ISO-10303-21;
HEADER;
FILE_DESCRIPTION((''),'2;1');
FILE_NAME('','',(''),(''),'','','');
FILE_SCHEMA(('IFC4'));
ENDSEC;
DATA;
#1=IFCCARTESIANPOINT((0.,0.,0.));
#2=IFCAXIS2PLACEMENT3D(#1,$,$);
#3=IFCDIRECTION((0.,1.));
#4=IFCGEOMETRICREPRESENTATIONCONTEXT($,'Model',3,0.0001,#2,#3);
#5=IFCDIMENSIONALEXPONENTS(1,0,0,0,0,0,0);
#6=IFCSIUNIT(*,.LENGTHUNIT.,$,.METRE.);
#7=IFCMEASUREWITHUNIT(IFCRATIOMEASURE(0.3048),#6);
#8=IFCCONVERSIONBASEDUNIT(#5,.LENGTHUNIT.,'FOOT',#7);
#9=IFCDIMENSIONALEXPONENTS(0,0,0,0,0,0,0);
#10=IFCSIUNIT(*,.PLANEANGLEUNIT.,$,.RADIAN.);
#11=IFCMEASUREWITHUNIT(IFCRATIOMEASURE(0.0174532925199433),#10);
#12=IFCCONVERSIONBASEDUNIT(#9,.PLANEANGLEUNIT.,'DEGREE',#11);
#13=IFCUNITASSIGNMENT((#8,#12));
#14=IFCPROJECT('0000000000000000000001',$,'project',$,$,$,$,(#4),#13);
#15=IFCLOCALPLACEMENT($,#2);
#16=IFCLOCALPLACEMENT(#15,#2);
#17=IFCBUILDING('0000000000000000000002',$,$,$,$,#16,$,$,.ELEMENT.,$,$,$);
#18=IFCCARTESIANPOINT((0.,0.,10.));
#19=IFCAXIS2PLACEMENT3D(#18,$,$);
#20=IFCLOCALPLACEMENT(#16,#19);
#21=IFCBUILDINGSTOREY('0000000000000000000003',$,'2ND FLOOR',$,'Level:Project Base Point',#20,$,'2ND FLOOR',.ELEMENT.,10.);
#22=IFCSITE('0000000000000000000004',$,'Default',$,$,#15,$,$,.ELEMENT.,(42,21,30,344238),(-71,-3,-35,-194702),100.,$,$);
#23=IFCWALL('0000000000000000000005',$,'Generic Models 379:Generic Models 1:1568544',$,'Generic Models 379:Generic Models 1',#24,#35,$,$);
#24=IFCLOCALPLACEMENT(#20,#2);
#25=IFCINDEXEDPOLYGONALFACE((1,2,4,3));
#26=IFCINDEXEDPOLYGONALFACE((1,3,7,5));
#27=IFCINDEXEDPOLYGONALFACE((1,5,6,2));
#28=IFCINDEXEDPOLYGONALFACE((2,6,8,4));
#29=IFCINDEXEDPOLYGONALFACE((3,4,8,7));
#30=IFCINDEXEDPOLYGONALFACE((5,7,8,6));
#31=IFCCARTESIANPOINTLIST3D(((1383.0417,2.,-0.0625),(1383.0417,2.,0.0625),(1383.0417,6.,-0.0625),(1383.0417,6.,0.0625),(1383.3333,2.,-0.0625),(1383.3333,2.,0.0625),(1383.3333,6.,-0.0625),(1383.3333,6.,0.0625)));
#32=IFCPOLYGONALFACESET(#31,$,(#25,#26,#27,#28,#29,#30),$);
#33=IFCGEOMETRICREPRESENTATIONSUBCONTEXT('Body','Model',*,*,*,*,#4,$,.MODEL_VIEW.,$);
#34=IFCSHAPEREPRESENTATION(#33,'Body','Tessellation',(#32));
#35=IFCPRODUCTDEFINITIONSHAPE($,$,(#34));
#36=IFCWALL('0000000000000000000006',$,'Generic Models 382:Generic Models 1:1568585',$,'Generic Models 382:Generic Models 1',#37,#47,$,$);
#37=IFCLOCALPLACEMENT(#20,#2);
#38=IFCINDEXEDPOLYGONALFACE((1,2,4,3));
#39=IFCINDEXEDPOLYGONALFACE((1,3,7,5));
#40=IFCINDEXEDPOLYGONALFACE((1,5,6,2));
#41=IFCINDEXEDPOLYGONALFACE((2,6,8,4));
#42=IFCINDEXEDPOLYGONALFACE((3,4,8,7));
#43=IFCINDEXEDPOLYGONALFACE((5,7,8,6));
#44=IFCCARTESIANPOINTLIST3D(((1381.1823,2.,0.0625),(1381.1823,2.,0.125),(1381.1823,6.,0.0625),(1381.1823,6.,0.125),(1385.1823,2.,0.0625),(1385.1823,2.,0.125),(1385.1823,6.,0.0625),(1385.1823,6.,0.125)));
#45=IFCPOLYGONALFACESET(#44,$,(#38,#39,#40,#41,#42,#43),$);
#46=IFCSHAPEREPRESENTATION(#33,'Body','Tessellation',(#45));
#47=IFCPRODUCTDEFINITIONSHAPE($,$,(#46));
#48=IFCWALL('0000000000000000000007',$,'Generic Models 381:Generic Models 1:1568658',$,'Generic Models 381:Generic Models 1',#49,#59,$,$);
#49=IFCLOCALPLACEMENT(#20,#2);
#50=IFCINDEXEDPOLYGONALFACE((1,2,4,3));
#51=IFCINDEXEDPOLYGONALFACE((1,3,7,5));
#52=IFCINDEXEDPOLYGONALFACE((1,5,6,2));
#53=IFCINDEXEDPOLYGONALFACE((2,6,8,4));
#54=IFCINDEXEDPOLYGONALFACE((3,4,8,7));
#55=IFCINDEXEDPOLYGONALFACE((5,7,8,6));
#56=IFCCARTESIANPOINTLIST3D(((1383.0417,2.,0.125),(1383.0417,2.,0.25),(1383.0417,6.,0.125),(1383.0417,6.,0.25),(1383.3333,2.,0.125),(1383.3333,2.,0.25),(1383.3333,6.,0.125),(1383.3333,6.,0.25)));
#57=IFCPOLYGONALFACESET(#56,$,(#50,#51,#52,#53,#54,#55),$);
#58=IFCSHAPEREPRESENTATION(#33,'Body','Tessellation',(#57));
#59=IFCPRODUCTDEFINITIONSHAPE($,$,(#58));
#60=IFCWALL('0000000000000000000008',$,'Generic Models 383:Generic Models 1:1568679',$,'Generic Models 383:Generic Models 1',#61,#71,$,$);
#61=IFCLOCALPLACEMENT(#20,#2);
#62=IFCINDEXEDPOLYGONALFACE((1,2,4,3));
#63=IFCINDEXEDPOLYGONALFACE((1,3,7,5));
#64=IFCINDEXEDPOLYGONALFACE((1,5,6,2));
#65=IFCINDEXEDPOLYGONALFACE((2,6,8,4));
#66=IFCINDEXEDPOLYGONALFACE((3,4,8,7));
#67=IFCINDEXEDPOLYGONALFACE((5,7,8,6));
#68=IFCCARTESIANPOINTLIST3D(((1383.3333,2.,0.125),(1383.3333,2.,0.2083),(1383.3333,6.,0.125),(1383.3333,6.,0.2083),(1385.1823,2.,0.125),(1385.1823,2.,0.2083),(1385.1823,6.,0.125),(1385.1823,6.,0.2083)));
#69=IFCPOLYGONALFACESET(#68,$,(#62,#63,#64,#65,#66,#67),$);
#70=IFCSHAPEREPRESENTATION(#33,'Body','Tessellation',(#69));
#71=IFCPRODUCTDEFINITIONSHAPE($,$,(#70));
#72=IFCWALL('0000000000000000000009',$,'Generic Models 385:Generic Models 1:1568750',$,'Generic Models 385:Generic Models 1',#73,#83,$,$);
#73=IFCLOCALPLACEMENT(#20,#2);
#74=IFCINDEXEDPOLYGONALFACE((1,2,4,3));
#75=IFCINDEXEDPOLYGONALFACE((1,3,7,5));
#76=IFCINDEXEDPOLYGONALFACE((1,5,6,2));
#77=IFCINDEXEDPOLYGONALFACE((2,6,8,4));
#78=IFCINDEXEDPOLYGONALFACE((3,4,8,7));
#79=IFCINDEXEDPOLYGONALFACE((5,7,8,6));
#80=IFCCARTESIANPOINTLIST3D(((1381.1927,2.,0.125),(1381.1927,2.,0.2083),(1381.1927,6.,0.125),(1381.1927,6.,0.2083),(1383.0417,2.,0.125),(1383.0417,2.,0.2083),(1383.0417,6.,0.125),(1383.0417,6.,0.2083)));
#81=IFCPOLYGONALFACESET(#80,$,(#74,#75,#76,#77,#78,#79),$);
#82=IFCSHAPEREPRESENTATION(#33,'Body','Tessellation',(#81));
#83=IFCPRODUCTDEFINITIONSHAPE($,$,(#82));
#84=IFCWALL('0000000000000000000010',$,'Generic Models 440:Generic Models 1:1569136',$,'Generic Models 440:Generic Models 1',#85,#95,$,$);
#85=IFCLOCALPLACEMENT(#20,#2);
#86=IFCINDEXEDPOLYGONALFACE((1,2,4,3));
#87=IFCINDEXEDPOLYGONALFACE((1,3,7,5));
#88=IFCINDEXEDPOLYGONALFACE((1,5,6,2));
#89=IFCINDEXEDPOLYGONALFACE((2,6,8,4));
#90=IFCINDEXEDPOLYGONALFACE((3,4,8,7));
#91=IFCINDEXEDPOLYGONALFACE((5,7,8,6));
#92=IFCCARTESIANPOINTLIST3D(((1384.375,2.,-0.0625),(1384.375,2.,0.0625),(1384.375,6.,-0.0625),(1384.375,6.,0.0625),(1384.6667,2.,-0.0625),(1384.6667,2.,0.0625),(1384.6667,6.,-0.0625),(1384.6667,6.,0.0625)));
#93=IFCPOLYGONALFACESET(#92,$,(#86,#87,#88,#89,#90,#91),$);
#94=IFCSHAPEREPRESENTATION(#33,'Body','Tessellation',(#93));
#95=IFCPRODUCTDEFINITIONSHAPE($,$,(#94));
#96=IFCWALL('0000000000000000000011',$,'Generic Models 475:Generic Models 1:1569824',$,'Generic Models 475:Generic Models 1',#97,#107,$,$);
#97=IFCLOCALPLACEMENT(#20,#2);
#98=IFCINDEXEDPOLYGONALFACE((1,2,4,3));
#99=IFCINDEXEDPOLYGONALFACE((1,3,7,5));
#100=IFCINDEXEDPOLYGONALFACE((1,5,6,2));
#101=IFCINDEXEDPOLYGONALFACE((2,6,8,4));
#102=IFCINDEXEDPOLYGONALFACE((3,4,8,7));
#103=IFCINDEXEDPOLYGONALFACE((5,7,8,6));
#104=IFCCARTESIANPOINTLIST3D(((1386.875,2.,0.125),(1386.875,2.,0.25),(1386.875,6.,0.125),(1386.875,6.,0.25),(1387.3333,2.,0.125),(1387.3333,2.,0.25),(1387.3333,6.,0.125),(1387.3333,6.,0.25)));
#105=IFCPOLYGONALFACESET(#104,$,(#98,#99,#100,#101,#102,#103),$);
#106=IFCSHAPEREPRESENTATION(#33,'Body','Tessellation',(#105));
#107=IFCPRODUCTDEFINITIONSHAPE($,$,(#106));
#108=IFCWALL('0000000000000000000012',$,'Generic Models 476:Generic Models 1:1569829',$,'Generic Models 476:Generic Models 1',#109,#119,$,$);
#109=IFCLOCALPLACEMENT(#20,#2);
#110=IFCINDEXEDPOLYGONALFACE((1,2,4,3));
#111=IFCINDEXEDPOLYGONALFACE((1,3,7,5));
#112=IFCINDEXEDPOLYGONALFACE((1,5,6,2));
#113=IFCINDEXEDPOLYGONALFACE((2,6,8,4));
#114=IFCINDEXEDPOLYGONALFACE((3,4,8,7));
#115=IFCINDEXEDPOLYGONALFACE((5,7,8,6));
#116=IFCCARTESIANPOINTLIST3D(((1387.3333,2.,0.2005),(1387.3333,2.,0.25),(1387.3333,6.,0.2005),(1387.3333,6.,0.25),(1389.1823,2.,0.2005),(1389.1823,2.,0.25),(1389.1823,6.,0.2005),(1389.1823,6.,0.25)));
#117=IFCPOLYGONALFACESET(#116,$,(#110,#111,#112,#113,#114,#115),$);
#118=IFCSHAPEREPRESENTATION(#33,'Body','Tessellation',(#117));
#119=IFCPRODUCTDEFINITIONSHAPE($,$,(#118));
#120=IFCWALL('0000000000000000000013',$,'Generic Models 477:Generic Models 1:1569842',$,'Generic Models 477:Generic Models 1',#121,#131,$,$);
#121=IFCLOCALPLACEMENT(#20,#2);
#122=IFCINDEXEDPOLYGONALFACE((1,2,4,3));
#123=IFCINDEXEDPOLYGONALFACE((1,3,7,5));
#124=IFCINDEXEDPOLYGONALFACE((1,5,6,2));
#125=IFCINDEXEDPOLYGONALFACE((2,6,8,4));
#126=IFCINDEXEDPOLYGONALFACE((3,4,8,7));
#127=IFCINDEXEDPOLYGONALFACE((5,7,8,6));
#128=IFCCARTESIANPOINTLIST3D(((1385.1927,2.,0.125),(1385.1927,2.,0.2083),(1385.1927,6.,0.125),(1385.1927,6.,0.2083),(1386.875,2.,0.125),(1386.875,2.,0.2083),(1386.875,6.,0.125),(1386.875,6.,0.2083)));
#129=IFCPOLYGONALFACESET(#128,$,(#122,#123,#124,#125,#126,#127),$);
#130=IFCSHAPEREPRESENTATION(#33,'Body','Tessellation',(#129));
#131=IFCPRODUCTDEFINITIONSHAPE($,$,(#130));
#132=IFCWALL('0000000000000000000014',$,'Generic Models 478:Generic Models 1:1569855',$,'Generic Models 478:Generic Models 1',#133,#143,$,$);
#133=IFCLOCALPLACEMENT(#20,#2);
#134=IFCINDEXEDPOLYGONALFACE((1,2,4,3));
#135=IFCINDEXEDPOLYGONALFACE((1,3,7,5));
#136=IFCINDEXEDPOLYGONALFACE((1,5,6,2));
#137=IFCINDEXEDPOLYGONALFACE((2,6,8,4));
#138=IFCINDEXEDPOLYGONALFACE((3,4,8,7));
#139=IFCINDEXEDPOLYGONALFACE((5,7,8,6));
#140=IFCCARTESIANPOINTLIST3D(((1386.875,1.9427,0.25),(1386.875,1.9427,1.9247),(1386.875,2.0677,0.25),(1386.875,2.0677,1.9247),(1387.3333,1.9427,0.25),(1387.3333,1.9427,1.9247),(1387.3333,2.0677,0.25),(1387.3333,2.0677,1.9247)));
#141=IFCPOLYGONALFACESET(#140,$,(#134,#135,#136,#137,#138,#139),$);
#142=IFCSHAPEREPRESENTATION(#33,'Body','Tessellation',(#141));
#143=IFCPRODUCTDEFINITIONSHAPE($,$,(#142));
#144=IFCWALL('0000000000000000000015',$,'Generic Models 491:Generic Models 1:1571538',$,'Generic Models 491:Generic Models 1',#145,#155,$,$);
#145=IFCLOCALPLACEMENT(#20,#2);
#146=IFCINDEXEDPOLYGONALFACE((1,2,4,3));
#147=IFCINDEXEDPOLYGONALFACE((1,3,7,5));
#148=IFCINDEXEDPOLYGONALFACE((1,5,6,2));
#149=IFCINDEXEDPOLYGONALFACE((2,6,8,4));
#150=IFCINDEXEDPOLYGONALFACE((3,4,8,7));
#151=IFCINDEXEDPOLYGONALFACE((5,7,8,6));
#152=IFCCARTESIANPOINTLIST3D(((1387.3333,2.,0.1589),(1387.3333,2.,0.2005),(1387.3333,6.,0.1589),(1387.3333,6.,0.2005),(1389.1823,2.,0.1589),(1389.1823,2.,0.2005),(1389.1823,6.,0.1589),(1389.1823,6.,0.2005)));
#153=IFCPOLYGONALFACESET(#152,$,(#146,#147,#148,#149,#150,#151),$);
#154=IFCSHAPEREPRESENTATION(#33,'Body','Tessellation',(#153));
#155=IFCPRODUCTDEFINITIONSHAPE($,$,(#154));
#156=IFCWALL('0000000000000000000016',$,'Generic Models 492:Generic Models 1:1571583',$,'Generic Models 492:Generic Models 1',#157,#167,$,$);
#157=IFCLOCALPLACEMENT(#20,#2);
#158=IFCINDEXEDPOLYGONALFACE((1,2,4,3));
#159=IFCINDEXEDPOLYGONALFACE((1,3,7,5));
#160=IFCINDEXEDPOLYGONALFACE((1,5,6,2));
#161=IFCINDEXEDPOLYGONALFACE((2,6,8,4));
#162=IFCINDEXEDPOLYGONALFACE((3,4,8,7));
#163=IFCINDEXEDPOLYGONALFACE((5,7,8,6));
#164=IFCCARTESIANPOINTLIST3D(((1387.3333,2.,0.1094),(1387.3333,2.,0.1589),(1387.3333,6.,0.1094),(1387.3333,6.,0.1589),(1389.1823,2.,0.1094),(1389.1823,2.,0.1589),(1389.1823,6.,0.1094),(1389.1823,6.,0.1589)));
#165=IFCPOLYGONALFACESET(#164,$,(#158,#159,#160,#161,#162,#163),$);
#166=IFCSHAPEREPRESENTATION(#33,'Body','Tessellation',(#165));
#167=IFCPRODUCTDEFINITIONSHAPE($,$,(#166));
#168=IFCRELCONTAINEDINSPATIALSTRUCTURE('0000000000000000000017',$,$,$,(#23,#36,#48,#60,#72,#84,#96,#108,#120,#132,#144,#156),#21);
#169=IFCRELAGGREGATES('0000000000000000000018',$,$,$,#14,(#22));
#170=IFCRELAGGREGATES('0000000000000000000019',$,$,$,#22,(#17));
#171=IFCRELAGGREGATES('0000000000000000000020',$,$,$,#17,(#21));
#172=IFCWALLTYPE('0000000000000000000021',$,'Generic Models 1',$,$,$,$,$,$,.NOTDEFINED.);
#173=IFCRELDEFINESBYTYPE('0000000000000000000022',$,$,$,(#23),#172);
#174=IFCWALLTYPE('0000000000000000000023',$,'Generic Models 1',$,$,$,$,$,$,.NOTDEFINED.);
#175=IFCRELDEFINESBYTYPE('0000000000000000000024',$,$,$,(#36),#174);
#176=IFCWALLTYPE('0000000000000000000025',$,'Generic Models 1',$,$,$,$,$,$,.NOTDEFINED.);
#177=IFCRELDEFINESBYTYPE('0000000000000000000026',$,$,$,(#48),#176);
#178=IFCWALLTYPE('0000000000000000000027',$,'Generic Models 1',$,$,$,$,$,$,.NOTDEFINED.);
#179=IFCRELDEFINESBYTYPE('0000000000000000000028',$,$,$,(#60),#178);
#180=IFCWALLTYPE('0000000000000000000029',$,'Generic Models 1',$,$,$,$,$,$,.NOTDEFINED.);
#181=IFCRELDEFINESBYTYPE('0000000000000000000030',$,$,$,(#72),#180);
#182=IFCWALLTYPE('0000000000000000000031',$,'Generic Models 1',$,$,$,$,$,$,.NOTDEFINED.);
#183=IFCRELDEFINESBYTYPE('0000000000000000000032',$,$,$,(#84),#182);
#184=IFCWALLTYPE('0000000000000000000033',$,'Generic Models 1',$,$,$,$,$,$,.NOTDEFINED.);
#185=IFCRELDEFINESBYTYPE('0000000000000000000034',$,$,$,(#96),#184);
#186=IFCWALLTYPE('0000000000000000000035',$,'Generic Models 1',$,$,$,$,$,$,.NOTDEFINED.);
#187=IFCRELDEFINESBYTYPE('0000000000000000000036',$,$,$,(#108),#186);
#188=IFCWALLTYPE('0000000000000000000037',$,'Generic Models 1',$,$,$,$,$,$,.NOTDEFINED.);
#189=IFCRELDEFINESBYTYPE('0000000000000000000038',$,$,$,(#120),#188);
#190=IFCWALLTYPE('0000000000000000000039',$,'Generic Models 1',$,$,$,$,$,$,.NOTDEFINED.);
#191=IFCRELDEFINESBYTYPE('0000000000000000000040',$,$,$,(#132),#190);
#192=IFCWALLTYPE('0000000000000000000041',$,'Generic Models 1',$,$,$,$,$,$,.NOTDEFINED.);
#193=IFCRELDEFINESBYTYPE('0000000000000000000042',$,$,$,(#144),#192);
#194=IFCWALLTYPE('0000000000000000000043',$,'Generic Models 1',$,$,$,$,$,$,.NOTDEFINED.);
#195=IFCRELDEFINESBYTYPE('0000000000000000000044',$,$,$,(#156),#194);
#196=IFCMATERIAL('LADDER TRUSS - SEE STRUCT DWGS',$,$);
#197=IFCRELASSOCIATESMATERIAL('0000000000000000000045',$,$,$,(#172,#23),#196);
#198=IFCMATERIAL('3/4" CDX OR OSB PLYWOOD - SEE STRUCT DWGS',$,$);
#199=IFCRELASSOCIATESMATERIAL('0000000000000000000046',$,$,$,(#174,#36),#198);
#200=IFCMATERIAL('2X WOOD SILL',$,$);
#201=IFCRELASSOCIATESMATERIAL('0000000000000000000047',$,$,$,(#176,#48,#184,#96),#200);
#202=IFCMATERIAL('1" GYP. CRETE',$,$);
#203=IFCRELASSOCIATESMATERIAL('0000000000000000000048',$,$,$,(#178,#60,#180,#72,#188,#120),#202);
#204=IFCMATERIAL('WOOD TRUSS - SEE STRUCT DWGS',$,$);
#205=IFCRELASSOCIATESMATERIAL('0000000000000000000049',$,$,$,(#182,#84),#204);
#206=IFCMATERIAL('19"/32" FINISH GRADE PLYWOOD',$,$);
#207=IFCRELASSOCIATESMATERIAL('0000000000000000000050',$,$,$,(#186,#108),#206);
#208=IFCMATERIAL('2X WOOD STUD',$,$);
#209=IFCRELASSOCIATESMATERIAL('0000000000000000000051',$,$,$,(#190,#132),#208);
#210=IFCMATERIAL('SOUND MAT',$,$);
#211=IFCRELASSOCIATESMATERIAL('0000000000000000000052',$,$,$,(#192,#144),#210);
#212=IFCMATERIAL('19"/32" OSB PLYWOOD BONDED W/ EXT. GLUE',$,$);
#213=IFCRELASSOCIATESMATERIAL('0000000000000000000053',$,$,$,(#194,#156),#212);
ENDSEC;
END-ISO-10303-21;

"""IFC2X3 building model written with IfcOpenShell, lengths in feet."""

from ifc_helpers import new_model, entity, si_unit, converted_unit, direction, frame, frame_2d, origin, origin_2d_with_axis, place, context, subcontext, project, spatial, rectangle, extrude, material, type_object, element, save


model = new_model("IFC2X3")

# Units and contexts
model_context = context("Model", 3, precision=0.0001, world=origin(), true_north=direction((0.0, 1.0)))
body_context = subcontext(model_context, "Body", "Model", "MODEL_VIEW")
ifc_project = project(units=[converted_unit("LENGTHUNIT", "FOOT", entity("IfcRatioMeasure", 0.3048), si_unit("LENGTHUNIT", "METRE"), dimensions=[1, 0, 0, 0, 0, 0, 0]), converted_unit("PLANEANGLEUNIT", "DEGREE", entity("IfcRatioMeasure", 0.0174532925199433), si_unit("PLANEANGLEUNIT", "RADIAN"), dimensions=[0, 0, 0, 0, 0, 0, 0])], contexts=[model_context])

# Site, building, storey
site_placement = place(None, origin())
site = spatial("IfcSite", under=ifc_project, at=site_placement, Name="Default", CompositionType="ELEMENT", RefLatitude=(42, 21, 30, 344238), RefLongitude=(-71, -3, -35, -194702), RefElevation=100.0)
building_placement = place(site_placement, origin())
building = spatial("IfcBuilding", under=site, at=building_placement, CompositionType="ELEMENT")
storey_placement = place(building_placement, frame((0.0, 0.0, 10.0)))
storey = spatial("IfcBuildingStorey", under=building, at=storey_placement, Name="2ND FLOOR", ObjectType="Level:Project Base Point", LongName="2ND FLOOR", CompositionType="ELEMENT", Elevation=10.0)

# Walls
ifc_material_1 = material(Name="LADDER TRUSS - SEE STRUCT DWGS")
wall_type_1 = type_object("IfcWallType", Name="Generic Models 1", PredefinedType="NOTDEFINED", material=ifc_material_1)
wall_1_placement = place(storey_placement, frame((1383.0417, 2.0, -0.0625), z_axis=(0.0, 0.0, 1.0), x_axis=(0.0, 1.0, 0.0)))
element("IfcWall", 1, at=wall_1_placement, inside=storey, type_object=wall_type_1, material=ifc_material_1, Name="Generic Models 379:Generic Models 1:1568544", ObjectType="Generic Models 379:Generic Models 1", context=body_context, shape_type="SweptSolid", body=[
    extrude(rectangle(XDim=4.0, YDim=0.2917, at=origin_2d_with_axis()), frame((2.0, -0.1458, 0.0)), (0.0, 0.0, 1.0), 0.125),
])
ifc_material_2 = material(Name="3/4\" CDX OR OSB PLYWOOD - SEE STRUCT DWGS")
wall_type_2 = type_object("IfcWallType", Name="Generic Models 1", PredefinedType="NOTDEFINED", material=ifc_material_2)
wall_2_placement = place(storey_placement, frame((1381.1823, 2.0, 0.0625), z_axis=(0.0, 0.0, 1.0), x_axis=(0.0, 1.0, 0.0)))
element("IfcWall", 2, at=wall_2_placement, inside=storey, type_object=wall_type_2, material=ifc_material_2, Name="Generic Models 382:Generic Models 1:1568585", ObjectType="Generic Models 382:Generic Models 1", context=body_context, shape_type="SweptSolid", body=[
    extrude(rectangle(XDim=4.0, YDim=4.0, at=frame_2d((0.0, 0.0), x_axis=(1.0, 0.0))), frame((2.0, -2.0, 0.0)), (0.0, 0.0, 1.0), 0.0625),
])
ifc_material_3 = material(Name="2X WOOD SILL")
wall_type_3 = type_object("IfcWallType", Name="Generic Models 1", PredefinedType="NOTDEFINED", material=ifc_material_3)
wall_3_placement = place(storey_placement, frame((1383.0417, 2.0, 0.125), z_axis=(0.0, 0.0, 1.0), x_axis=(0.0, 1.0, 0.0)))
element("IfcWall", 3, at=wall_3_placement, inside=storey, type_object=wall_type_3, material=ifc_material_3, Name="Generic Models 381:Generic Models 1:1568658", ObjectType="Generic Models 381:Generic Models 1", context=body_context, shape_type="SweptSolid", body=[
    extrude(rectangle(XDim=4.0, YDim=0.2917, at=frame_2d((0.0, 0.0), x_axis=(1.0, 0.0))), frame((2.0, -0.1458, 0.0)), (0.0, 0.0, 1.0), 0.125),
])
ifc_material_4 = material(Name="1\" GYP. CRETE")
wall_type_4 = type_object("IfcWallType", Name="Generic Models 1", PredefinedType="NOTDEFINED", material=ifc_material_4)
wall_4_placement = place(storey_placement, frame((1383.3333, 2.0, 0.125), z_axis=(0.0, 0.0, 1.0), x_axis=(0.0, 1.0, 0.0)))
element("IfcWall", 4, at=wall_4_placement, inside=storey, type_object=wall_type_4, material=ifc_material_4, Name="Generic Models 383:Generic Models 1:1568679", ObjectType="Generic Models 383:Generic Models 1", context=body_context, shape_type="SweptSolid", body=[
    extrude(rectangle(XDim=4.0, YDim=1.849, at=frame_2d((0.0, 0.0), x_axis=(1.0, 0.0))), frame((2.0, -0.9245, 0.0)), (0.0, 0.0, 1.0), 0.0833),
])
wall_type_5 = type_object("IfcWallType", Name="Generic Models 1", PredefinedType="NOTDEFINED", material=ifc_material_4)
wall_5_placement = place(storey_placement, frame((1381.1927, 2.0, 0.125), z_axis=(0.0, 0.0, 1.0), x_axis=(0.0, 1.0, 0.0)))
element("IfcWall", 5, at=wall_5_placement, inside=storey, type_object=wall_type_5, material=ifc_material_4, Name="Generic Models 385:Generic Models 1:1568750", ObjectType="Generic Models 385:Generic Models 1", context=body_context, shape_type="SweptSolid", body=[
    extrude(rectangle(XDim=4.0, YDim=1.849, at=frame_2d((0.0, 0.0), x_axis=(1.0, 0.0))), frame((2.0, -0.9245, 0.0)), (0.0, 0.0, 1.0), 0.0833),
])
ifc_material_5 = material(Name="WOOD TRUSS - SEE STRUCT DWGS")
wall_type_6 = type_object("IfcWallType", Name="Generic Models 1", PredefinedType="NOTDEFINED", material=ifc_material_5)
wall_6_placement = place(storey_placement, frame((1384.375, 2.0, -0.0625), z_axis=(0.0, 0.0, 1.0), x_axis=(0.0, 1.0, 0.0)))
element("IfcWall", 6, at=wall_6_placement, inside=storey, type_object=wall_type_6, material=ifc_material_5, Name="Generic Models 440:Generic Models 1:1569136", ObjectType="Generic Models 440:Generic Models 1", context=body_context, shape_type="SweptSolid", body=[
    extrude(rectangle(XDim=4.0, YDim=0.2917, at=frame_2d((0.0, 0.0), x_axis=(1.0, 0.0))), frame((2.0, -0.1458, 0.0)), (0.0, 0.0, 1.0), 0.125),
])
wall_type_7 = type_object("IfcWallType", Name="Generic Models 1", PredefinedType="NOTDEFINED", material=ifc_material_3)
wall_7_placement = place(storey_placement, frame((1386.875, 2.0, 0.125), z_axis=(0.0, 0.0, 1.0), x_axis=(0.0, 1.0, 0.0)))
element("IfcWall", 7, at=wall_7_placement, inside=storey, type_object=wall_type_7, material=ifc_material_3, Name="Generic Models 475:Generic Models 1:1569824", ObjectType="Generic Models 475:Generic Models 1", context=body_context, shape_type="SweptSolid", body=[
    extrude(rectangle(XDim=4.0, YDim=0.4583, at=frame_2d((0.0, 0.0), x_axis=(1.0, 0.0))), frame((2.0, -0.2292, 0.0)), (0.0, 0.0, 1.0), 0.125),
])
ifc_material_6 = material(Name="19\"/32\" FINISH GRADE PLYWOOD")
wall_type_8 = type_object("IfcWallType", Name="Generic Models 1", PredefinedType="NOTDEFINED", material=ifc_material_6)
wall_8_placement = place(storey_placement, frame((1387.3333, 2.0, 0.2005), z_axis=(0.0, 0.0, 1.0), x_axis=(0.0, 1.0, 0.0)))
element("IfcWall", 8, at=wall_8_placement, inside=storey, type_object=wall_type_8, material=ifc_material_6, Name="Generic Models 476:Generic Models 1:1569829", ObjectType="Generic Models 476:Generic Models 1", context=body_context, shape_type="SweptSolid", body=[
    extrude(rectangle(XDim=4.0, YDim=1.849, at=frame_2d((0.0, 0.0), x_axis=(1.0, 0.0))), frame((2.0, -0.9245, 0.0)), (0.0, 0.0, 1.0), 0.0495),
])
wall_type_9 = type_object("IfcWallType", Name="Generic Models 1", PredefinedType="NOTDEFINED", material=ifc_material_4)
wall_9_placement = place(storey_placement, frame((1385.1927, 2.0, 0.125), z_axis=(0.0, 0.0, 1.0), x_axis=(0.0, 1.0, 0.0)))
element("IfcWall", 9, at=wall_9_placement, inside=storey, type_object=wall_type_9, material=ifc_material_4, Name="Generic Models 477:Generic Models 1:1569842", ObjectType="Generic Models 477:Generic Models 1", context=body_context, shape_type="SweptSolid", body=[
    extrude(rectangle(XDim=4.0, YDim=1.6823, at=frame_2d((0.0, 0.0), x_axis=(1.0, 0.0))), frame((2.0, -0.8411, 0.0)), (0.0, 0.0, 1.0), 0.0833),
])
ifc_material_7 = material(Name="2X WOOD STUD")
wall_type_10 = type_object("IfcWallType", Name="Generic Models 1", PredefinedType="NOTDEFINED", material=ifc_material_7)
wall_10_placement = place(storey_placement, frame((1386.875, 1.9427, 0.25)))
element("IfcWall", 10, at=wall_10_placement, inside=storey, type_object=wall_type_10, material=ifc_material_7, Name="Generic Models 478:Generic Models 1:1569855", ObjectType="Generic Models 478:Generic Models 1", context=body_context, shape_type="SweptSolid", body=[
    extrude(rectangle(XDim=0.125, YDim=0.4583, at=frame_2d((0.0, 0.0), x_axis=(1.0, 0.0))), frame((0.2292, 0.0625, 0.0), z_axis=(0.0, 0.0, 1.0), x_axis=(0.0, 1.0, 0.0)), (0.0, 0.0, 1.0), 1.6747),
])
ifc_material_8 = material(Name="SOUND MAT")
wall_type_11 = type_object("IfcWallType", Name="Generic Models 1", PredefinedType="NOTDEFINED", material=ifc_material_8)
wall_11_placement = place(storey_placement, frame((1387.3333, 2.0, 0.1589), z_axis=(0.0, 0.0, 1.0), x_axis=(0.0, 1.0, 0.0)))
element("IfcWall", 11, at=wall_11_placement, inside=storey, type_object=wall_type_11, material=ifc_material_8, Name="Generic Models 491:Generic Models 1:1571538", ObjectType="Generic Models 491:Generic Models 1", context=body_context, shape_type="SweptSolid", body=[
    extrude(rectangle(XDim=4.0, YDim=1.849, at=frame_2d((0.0, 0.0), x_axis=(1.0, 0.0))), frame((2.0, -0.9245, 0.0)), (0.0, 0.0, 1.0), 0.0417),
])
ifc_material_9 = material(Name="19\"/32\" OSB PLYWOOD BONDED W/ EXT. GLUE")
wall_type_12 = type_object("IfcWallType", Name="Generic Models 1", PredefinedType="NOTDEFINED", material=ifc_material_9)
wall_12_placement = place(storey_placement, frame((1387.3333, 2.0, 0.1094), z_axis=(0.0, 0.0, 1.0), x_axis=(0.0, 1.0, 0.0)))
element("IfcWall", 12, at=wall_12_placement, inside=storey, type_object=wall_type_12, material=ifc_material_9, Name="Generic Models 492:Generic Models 1:1571583", ObjectType="Generic Models 492:Generic Models 1", context=body_context, shape_type="SweptSolid", body=[
    extrude(rectangle(XDim=4.0, YDim=1.849, at=frame_2d((0.0, 0.0), x_axis=(1.0, 0.0))), frame((2.0, -0.9245, 0.0)), (0.0, 0.0, 1.0), 0.0495),
])

save(model, "model.ifc")
